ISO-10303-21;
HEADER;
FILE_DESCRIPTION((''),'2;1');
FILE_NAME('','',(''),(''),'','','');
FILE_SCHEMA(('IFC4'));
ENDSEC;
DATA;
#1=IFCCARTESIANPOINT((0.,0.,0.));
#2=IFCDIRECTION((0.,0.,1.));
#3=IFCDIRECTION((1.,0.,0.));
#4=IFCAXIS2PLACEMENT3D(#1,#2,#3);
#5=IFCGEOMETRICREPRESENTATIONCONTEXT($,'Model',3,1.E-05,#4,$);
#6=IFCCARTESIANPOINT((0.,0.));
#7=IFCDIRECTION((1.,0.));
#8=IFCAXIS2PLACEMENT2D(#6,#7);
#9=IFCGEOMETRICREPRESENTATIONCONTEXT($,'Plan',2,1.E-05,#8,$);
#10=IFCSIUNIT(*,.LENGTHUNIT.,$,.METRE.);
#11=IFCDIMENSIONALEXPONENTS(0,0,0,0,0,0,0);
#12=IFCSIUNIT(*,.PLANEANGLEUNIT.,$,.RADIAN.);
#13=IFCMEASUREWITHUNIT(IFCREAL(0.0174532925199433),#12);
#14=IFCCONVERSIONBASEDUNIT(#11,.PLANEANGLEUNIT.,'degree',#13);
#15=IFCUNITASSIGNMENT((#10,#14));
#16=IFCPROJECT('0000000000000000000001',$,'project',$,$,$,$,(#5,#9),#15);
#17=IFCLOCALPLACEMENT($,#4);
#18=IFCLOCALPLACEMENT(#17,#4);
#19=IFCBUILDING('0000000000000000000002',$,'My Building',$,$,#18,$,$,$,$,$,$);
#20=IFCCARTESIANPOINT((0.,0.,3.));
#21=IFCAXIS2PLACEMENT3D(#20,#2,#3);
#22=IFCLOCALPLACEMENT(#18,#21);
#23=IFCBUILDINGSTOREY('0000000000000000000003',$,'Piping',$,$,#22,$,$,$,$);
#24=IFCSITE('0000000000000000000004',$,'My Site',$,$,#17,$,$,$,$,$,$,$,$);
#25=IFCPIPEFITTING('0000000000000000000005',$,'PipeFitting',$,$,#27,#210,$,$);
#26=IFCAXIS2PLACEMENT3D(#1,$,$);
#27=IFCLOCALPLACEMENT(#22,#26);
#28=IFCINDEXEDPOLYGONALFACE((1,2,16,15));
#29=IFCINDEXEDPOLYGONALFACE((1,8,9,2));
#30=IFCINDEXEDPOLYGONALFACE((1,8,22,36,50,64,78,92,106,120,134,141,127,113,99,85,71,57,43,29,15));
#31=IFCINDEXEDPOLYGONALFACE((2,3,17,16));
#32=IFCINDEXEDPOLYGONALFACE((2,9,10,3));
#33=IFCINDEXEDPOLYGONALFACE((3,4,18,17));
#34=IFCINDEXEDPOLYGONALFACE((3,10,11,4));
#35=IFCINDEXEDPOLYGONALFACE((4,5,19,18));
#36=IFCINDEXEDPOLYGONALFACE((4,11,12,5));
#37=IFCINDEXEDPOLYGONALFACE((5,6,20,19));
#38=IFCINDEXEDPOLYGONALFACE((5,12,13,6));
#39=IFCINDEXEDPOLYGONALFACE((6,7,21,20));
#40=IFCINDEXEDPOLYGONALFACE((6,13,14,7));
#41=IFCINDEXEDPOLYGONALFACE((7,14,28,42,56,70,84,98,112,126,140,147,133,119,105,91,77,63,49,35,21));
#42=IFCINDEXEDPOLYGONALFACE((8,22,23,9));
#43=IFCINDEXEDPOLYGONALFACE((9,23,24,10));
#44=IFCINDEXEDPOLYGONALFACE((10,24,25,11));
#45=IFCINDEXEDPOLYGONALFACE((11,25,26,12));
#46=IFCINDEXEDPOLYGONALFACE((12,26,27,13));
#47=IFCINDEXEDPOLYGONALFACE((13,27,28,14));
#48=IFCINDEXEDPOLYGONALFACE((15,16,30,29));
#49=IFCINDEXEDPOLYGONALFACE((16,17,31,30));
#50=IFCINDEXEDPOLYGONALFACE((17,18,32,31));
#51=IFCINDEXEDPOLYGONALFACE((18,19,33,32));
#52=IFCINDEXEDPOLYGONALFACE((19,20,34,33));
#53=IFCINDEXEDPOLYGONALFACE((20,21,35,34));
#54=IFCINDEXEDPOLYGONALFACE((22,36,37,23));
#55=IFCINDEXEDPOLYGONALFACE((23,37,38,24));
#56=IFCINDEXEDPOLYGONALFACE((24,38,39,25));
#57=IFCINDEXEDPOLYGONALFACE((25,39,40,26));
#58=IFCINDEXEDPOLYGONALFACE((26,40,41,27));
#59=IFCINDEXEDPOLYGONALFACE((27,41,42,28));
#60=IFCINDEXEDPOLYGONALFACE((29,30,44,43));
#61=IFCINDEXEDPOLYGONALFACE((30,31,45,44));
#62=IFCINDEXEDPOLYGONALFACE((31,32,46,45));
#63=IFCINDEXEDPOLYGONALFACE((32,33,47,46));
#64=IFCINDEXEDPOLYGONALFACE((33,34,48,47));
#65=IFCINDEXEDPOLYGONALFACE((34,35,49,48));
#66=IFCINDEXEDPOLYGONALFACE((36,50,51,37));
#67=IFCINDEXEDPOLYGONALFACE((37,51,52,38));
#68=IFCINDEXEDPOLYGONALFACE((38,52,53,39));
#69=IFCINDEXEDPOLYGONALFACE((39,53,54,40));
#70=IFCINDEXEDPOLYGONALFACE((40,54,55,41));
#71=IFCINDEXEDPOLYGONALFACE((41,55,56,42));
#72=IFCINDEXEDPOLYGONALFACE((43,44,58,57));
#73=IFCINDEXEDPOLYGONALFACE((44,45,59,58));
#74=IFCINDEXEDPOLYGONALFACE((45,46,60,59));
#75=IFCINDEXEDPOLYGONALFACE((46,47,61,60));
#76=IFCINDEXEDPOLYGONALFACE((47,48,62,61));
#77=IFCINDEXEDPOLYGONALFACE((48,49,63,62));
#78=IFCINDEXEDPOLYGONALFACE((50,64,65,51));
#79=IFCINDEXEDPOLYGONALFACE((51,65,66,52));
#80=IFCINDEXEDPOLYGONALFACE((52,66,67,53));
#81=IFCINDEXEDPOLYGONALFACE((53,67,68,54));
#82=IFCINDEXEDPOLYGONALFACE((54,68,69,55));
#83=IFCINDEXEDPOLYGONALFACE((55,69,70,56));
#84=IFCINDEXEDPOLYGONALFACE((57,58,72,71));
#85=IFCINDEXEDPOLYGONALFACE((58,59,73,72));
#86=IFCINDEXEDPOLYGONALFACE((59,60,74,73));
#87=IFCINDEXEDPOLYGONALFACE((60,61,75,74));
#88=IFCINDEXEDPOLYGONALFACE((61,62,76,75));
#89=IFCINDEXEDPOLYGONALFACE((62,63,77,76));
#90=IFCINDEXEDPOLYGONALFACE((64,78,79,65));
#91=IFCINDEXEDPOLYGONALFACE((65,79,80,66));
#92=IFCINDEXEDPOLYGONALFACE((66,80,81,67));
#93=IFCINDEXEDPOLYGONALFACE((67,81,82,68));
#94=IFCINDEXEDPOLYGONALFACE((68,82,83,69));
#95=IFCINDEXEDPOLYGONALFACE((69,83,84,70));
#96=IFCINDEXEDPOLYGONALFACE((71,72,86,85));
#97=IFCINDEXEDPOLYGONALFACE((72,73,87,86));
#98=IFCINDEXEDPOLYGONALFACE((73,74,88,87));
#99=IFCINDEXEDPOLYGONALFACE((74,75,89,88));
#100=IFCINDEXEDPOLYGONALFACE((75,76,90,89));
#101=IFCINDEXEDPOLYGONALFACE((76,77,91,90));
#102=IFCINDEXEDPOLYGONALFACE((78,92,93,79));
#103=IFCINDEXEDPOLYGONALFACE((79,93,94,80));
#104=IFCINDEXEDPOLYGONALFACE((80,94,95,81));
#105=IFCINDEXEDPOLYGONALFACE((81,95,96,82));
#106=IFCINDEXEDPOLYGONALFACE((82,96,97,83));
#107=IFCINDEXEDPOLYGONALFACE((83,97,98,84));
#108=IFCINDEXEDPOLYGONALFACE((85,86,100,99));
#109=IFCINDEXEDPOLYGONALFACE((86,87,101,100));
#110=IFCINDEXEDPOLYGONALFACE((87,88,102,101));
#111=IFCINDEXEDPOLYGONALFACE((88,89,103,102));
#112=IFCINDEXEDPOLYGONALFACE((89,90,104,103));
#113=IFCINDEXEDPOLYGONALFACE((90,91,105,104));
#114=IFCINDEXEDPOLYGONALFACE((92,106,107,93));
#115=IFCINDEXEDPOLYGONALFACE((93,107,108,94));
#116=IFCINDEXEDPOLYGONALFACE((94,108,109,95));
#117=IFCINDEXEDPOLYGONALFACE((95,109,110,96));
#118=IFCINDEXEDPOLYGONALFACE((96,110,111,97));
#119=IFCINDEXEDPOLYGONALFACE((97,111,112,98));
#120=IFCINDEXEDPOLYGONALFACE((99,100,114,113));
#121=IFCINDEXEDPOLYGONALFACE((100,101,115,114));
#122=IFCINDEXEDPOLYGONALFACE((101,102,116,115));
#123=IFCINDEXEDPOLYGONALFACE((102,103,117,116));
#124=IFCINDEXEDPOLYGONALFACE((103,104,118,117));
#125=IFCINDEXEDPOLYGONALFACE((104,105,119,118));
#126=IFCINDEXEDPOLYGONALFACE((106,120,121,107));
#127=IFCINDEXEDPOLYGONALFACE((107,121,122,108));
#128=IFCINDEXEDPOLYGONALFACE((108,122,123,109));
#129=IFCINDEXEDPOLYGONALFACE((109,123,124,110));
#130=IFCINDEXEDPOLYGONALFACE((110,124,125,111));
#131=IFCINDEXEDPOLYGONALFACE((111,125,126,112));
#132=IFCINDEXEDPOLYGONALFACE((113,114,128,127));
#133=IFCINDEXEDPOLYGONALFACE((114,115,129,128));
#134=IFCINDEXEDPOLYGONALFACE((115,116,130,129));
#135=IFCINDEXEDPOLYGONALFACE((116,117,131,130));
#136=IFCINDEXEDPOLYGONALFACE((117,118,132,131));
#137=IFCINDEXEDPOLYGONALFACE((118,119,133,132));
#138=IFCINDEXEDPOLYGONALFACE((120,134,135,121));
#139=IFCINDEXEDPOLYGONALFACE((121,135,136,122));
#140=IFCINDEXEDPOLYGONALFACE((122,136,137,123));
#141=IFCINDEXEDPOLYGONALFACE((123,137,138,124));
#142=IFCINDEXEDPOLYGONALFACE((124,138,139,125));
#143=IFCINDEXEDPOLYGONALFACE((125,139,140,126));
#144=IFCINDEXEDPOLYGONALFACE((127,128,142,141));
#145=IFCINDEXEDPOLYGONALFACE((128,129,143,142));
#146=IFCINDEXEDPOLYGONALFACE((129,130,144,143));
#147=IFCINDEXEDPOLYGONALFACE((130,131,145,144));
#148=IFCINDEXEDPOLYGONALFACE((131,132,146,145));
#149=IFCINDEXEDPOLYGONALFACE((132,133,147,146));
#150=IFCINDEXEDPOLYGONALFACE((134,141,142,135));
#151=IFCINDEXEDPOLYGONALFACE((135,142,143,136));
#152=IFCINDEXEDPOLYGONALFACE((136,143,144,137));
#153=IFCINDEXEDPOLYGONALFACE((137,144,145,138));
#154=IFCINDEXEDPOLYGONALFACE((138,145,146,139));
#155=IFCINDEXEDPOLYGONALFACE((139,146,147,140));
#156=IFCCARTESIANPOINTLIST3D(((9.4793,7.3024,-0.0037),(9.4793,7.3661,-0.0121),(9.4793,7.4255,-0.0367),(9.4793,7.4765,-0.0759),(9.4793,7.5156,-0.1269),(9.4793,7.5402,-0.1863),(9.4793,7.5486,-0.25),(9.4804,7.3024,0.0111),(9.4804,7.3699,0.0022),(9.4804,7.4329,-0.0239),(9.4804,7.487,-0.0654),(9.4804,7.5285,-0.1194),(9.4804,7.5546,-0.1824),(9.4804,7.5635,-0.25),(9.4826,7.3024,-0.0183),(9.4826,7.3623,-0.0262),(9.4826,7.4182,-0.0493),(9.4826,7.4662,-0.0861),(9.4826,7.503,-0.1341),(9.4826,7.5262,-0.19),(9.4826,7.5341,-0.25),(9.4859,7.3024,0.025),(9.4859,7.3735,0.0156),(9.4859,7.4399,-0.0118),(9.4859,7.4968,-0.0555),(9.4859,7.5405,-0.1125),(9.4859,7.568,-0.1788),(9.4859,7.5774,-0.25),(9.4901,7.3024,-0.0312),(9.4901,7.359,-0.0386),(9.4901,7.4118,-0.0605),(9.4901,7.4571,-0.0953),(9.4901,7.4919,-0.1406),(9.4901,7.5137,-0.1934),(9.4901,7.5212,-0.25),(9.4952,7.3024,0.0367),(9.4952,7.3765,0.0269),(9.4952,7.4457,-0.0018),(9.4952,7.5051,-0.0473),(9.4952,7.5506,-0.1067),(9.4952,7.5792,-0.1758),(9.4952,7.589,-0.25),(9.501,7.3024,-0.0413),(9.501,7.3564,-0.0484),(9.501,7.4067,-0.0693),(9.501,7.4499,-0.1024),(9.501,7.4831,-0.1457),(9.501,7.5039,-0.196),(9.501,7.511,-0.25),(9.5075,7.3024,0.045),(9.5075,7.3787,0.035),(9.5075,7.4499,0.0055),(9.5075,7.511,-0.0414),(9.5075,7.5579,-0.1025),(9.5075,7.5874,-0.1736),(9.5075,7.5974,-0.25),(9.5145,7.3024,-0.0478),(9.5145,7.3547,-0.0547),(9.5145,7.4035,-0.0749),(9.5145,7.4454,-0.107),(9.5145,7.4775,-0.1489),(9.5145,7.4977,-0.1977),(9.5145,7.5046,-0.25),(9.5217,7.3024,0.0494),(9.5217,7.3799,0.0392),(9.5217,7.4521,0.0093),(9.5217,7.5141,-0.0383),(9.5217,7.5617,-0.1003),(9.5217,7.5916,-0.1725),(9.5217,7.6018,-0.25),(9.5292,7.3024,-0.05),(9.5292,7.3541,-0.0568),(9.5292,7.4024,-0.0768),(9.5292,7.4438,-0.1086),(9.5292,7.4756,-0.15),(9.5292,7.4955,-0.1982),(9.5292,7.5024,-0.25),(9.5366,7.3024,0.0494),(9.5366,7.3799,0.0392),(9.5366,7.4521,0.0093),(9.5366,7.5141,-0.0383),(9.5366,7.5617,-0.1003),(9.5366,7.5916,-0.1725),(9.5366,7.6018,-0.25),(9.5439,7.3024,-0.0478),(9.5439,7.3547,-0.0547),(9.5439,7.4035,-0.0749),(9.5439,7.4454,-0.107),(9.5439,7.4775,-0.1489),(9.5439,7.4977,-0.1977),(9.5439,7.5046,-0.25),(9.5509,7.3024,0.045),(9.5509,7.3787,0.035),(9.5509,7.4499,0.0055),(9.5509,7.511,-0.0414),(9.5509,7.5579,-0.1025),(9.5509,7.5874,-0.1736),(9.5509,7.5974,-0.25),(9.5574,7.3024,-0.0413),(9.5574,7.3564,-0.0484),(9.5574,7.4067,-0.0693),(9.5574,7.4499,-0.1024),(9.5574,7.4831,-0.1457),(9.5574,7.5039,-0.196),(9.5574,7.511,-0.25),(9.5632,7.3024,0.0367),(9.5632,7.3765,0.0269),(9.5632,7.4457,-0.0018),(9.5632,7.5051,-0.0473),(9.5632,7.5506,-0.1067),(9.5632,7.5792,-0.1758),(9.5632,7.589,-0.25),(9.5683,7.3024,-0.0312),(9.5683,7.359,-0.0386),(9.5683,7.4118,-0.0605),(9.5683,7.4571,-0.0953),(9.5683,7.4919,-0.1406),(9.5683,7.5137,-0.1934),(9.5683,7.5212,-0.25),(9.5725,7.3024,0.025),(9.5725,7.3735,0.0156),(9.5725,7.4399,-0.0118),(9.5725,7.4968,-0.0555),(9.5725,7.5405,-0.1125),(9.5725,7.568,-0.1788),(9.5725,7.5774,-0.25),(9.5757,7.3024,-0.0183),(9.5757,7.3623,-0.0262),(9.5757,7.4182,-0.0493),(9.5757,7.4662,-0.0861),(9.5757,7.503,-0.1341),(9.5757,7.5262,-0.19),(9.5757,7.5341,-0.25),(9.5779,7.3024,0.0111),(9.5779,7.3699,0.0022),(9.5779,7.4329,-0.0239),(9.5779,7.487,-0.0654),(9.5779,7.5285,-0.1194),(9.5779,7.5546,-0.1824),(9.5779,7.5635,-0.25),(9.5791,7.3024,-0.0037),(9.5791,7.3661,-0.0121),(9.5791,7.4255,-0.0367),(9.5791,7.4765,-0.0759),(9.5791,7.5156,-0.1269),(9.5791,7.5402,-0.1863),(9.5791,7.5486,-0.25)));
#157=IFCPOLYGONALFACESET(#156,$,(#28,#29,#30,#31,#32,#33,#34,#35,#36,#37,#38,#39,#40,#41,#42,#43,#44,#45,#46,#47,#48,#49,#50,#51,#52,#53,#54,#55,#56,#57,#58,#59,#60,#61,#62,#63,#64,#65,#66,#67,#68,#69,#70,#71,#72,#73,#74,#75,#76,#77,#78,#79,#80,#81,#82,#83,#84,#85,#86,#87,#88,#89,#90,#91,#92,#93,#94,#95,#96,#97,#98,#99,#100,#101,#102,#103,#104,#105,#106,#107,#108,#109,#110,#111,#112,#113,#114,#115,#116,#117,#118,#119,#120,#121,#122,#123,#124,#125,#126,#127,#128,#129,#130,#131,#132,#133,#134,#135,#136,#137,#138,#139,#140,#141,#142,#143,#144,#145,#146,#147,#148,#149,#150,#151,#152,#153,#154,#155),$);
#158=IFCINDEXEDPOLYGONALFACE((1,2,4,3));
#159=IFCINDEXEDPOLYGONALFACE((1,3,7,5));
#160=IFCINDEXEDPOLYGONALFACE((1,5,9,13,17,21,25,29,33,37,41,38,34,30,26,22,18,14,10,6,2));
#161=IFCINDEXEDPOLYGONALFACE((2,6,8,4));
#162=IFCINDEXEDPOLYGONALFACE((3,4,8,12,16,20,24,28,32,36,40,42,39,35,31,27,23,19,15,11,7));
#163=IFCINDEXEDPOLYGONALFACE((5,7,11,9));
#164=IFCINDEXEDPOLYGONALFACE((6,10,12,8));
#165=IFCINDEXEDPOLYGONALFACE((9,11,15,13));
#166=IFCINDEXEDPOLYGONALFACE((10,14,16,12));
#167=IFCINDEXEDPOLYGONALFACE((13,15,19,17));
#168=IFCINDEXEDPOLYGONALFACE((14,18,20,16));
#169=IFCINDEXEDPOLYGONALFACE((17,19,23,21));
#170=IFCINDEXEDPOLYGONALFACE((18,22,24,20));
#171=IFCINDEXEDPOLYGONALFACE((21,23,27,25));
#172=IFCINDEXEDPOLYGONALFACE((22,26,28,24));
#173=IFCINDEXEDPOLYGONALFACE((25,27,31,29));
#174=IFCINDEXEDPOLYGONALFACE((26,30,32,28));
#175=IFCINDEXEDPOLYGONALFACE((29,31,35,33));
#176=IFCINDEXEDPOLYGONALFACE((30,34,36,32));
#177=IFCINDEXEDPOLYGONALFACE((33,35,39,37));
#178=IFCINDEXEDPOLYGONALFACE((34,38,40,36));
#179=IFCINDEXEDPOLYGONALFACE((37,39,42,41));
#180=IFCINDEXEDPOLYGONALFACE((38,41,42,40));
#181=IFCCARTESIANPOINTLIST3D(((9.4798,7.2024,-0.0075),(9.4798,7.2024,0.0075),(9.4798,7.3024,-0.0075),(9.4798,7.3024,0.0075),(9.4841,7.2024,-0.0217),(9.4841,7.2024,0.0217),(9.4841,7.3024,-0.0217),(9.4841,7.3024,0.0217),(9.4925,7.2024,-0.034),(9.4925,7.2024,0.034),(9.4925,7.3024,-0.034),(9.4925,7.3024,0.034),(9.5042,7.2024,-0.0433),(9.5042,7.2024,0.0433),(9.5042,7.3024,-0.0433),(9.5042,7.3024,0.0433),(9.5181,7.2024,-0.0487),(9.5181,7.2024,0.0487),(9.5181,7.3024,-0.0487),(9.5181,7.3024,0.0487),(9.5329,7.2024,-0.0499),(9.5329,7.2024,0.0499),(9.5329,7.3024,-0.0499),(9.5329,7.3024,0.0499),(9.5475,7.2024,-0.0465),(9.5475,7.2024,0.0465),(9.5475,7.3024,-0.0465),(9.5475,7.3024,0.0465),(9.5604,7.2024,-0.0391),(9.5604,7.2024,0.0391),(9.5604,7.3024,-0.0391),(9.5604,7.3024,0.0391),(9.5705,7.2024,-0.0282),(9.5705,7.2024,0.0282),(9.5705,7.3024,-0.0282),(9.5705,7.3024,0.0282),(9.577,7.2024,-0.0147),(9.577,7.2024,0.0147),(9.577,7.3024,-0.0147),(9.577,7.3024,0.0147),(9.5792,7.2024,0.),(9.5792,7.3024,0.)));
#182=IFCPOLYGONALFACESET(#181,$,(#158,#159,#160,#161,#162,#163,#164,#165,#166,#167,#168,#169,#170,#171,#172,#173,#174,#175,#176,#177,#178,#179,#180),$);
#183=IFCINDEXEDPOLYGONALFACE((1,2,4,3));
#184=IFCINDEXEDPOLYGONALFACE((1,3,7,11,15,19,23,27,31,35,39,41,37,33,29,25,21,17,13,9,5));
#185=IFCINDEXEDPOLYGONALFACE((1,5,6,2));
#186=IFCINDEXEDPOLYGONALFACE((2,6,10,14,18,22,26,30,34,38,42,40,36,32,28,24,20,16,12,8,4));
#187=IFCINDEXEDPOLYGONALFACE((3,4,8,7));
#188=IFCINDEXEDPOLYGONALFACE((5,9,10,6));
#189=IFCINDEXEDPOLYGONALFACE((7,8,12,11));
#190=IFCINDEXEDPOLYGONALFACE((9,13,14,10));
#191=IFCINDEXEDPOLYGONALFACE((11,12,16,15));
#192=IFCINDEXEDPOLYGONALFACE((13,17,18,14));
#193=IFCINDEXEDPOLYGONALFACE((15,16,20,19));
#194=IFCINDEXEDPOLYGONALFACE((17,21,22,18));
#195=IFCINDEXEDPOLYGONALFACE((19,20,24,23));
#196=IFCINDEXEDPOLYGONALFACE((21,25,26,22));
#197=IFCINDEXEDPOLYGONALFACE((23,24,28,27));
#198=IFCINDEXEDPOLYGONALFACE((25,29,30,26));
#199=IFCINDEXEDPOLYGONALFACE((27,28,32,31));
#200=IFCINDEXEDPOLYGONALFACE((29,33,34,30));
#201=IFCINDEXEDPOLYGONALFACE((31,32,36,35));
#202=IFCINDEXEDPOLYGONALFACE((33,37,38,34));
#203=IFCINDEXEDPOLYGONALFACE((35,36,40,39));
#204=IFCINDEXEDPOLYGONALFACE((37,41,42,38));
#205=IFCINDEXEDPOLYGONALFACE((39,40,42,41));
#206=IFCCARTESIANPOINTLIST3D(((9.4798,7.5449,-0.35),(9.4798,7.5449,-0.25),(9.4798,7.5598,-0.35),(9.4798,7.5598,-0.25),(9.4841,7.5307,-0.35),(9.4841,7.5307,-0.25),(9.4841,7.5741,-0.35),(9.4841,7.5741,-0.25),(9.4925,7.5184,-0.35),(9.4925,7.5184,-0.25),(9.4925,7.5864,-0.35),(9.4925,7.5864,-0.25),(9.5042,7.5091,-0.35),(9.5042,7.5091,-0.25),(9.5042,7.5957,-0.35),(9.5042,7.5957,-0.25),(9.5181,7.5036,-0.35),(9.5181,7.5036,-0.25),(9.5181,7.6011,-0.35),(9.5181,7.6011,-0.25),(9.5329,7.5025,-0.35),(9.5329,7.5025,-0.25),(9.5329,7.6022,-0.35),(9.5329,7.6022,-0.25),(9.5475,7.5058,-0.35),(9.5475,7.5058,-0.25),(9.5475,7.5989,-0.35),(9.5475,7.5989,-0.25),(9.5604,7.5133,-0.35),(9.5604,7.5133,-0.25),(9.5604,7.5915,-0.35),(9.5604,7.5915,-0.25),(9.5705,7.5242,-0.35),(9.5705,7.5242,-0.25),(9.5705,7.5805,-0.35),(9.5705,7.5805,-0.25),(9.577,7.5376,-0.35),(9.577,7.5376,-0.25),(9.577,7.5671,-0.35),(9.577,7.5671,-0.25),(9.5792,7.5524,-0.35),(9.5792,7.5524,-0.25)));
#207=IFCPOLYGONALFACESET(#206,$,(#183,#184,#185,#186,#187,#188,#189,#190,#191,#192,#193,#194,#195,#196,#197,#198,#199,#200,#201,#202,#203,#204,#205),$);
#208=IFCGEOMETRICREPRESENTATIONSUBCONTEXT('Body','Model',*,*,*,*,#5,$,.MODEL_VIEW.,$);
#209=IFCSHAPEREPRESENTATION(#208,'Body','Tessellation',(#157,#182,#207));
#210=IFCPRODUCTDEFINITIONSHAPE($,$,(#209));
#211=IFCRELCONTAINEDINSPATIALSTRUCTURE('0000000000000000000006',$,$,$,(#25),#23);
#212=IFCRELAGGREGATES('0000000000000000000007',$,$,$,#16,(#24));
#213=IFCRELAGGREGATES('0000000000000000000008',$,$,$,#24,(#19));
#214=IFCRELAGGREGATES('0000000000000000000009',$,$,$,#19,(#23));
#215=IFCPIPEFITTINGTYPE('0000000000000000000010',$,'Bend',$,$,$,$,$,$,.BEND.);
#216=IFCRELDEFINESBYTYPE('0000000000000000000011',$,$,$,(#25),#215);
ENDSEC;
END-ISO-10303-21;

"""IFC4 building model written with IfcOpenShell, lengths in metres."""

from ifc_helpers import new_model, entity, si_unit, converted_unit, frame, origin_with_axes, origin_2d_with_axis, place, context, subcontext, project, spatial, circle, extrude, source, transform, mapped, type_object, type_shapes, element, save


model = new_model("IFC4")

# Units and contexts
model_context = context("Model", 3, precision=1e-05, world=origin_with_axes())
plan_context = context("Plan", 2, precision=1e-05, world=origin_2d_with_axis())
body_context = subcontext(model_context, "Body", "Model", "MODEL_VIEW")
ifc_project = project(units=[si_unit("LENGTHUNIT", "METRE"), converted_unit("PLANEANGLEUNIT", "degree", entity("IfcReal", 0.0174532925199433), si_unit("PLANEANGLEUNIT", "RADIAN"), dimensions=[0, 0, 0, 0, 0, 0, 0])], contexts=[model_context, plan_context])

# Site, building, storey
site_placement = place(None, origin_with_axes())
site = spatial("IfcSite", under=ifc_project, at=site_placement, Name="My Site")
building_placement = place(site_placement, origin_with_axes())
building = spatial("IfcBuilding", under=site, at=building_placement, Name="My Building")
storey_placement = place(building_placement, frame((0.0, 0.0, 3.0), z_axis=(0.0, 0.0, 1.0), x_axis=(1.0, 0.0, 0.0)))
storey = spatial("IfcBuildingStorey", under=building, at=storey_placement, Name="Piping")

# Shared definitions
pipe_fitting_type_1 = type_object("IfcPipeFittingType", Name="Bend", PredefinedType="BEND")
shared_shape = source(origin_with_axes(), body_context, "Body", "SolidModel", [
    entity("IfcSweptDiskSolid", entity("IfcIndexedPolyCurve", entity("IfcCartesianPointList3D", [[0.0, 0.0, -0.1], [0.0, -0.0732, -0.2768], [0.0, -0.25, -0.35]]), [entity("IfcArcIndex", [1, 2, 3])]), 0.05),
    extrude(circle(Radius=0.05), origin_with_axes(), (0.0, 0.0, -1.0), 0.1),
    extrude(circle(Radius=0.05), frame((0.0, -0.25, -0.35), z_axis=(0.0, -1.0, 0.0), x_axis=(1.0, 0.0, 0.0)), (0.0, 0.0, 1.0), 0.1),
])
type_shapes(pipe_fitting_type_1, [shared_shape])

# Pipe fitting
for number, where, z_axis, x_axis, name in (
    (1, (9.5292, 7.2024, 0.0), (0.0, -1.0, 0.0), (1.0, 0.0, 0.0), "PipeFitting"),
):
    element("IfcPipeFitting", number, at=place(storey_placement, frame(where, z_axis=z_axis, x_axis=x_axis)), inside=storey, type_object=pipe_fitting_type_1, Name=name, context=body_context, shape_type="MappedRepresentation", body=[
        mapped(shared_shape, transform((0.0, 0.0, 0.0), x_axis=(1.0, 0.0, 0.0), y_axis=(0.0, 1.0, 0.0), z_axis=(0.0, 0.0, 1.0), scale=1.0)),
    ])

save(model, "model.ifc")
